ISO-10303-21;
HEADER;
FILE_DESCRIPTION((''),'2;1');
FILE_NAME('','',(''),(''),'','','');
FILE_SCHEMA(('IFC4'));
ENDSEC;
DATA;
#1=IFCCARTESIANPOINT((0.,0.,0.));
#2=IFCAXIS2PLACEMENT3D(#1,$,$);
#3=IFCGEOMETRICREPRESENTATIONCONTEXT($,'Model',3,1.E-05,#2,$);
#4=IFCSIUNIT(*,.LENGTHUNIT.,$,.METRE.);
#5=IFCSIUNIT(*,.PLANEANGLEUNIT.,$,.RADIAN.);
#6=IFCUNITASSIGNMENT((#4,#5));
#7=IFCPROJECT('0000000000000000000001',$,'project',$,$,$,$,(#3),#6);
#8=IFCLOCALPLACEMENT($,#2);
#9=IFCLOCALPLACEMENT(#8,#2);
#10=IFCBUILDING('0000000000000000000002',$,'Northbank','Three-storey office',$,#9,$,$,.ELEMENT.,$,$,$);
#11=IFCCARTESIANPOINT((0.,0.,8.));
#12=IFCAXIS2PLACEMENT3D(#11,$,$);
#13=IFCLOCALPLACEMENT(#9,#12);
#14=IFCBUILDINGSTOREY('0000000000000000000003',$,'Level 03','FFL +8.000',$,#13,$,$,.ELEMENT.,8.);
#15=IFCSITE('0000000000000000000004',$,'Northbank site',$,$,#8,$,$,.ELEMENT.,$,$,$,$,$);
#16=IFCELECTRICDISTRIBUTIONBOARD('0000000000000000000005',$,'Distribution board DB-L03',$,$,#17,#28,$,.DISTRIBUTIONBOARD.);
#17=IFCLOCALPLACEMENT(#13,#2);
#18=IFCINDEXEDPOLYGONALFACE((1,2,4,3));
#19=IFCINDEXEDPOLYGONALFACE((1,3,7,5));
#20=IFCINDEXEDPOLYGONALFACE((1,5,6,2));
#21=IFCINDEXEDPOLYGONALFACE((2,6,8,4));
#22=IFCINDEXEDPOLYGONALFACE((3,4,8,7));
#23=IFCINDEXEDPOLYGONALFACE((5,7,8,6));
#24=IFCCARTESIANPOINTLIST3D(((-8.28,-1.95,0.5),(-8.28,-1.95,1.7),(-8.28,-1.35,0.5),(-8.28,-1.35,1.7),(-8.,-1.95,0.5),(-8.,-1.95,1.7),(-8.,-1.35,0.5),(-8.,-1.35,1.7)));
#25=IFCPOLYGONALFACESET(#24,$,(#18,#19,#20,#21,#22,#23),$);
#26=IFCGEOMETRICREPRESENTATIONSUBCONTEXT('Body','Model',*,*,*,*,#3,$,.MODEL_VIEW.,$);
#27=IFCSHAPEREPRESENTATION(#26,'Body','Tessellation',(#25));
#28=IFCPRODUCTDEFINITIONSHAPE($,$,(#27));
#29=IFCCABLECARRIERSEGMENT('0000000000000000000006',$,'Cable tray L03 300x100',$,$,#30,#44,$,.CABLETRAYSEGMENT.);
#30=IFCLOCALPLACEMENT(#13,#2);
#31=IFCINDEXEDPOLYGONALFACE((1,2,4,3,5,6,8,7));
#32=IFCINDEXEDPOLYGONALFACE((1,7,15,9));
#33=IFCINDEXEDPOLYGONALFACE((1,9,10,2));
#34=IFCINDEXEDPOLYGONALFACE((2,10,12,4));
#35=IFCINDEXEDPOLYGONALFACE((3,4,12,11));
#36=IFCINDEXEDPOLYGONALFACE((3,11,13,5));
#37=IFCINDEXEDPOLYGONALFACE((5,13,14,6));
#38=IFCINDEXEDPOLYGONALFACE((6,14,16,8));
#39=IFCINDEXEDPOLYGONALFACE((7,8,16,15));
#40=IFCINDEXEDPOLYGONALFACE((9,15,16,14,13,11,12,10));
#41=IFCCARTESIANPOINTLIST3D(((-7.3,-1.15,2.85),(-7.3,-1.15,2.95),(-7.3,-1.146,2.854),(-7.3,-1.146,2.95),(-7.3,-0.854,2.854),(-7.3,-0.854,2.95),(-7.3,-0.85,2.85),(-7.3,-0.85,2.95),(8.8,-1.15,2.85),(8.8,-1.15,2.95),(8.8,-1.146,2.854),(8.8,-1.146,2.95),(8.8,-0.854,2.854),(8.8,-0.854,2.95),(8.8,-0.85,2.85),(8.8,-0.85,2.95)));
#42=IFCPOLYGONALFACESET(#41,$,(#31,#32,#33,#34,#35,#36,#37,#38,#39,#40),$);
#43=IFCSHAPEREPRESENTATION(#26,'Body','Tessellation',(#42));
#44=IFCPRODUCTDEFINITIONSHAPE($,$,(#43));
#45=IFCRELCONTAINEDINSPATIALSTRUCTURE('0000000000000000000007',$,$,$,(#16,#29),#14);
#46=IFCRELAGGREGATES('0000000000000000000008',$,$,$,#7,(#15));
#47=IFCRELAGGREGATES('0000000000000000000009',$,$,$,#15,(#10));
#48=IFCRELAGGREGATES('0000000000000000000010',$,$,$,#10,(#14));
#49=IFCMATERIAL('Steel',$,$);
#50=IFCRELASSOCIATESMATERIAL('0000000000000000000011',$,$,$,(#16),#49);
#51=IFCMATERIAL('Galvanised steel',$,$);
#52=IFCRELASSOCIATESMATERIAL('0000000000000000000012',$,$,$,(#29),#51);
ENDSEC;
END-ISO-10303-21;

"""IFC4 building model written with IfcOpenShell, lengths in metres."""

from ifc_helpers import new_model, si_unit, frame, origin, place, context, subcontext, project, spatial, rectangle, u_section, extrude, material, element, save


model = new_model("IFC4")

# Units and contexts
model_context = context("Model", 3, precision=1e-05, world=origin())
body_context = subcontext(model_context, "Body", "Model", "MODEL_VIEW")
ifc_project = project(units=[si_unit("LENGTHUNIT", "METRE"), si_unit("PLANEANGLEUNIT", "RADIAN")], contexts=[model_context])

# Site, building, storey
site_placement = place(None, origin())
site = spatial("IfcSite", under=ifc_project, at=site_placement, Name="Northbank site", CompositionType="ELEMENT")
building_placement = place(site_placement, origin())
building = spatial("IfcBuilding", under=site, at=building_placement, Name="Northbank", Description="Three-storey office", CompositionType="ELEMENT")
storey_placement = place(building_placement, frame((0.0, 0.0, 8.0)))
storey = spatial("IfcBuildingStorey", under=building, at=storey_placement, Name="Level 03", Description="FFL +8.000", CompositionType="ELEMENT", Elevation=8.0)

# Electric distribution board
ifc_material_1 = material(Name="Steel")
electric_distribution_board_placement = place(storey_placement, frame((0.0, 0.0, -8.0)))
element("IfcElectricDistributionBoard", 1, at=electric_distribution_board_placement, inside=storey, material=ifc_material_1, Name="Distribution board DB-L03", PredefinedType="DISTRIBUTIONBOARD", context=body_context, shape_type="SweptSolid", body=[
    extrude(rectangle(XDim=0.28, YDim=0.6), frame((-8.14, -1.65, 8.5)), (0.0, 0.0, 1.0), 1.2),
])

# Cable carrier segment
ifc_material_2 = material(Name="Galvanised steel")
cable_carrier_segment_1_placement = place(storey_placement, frame((0.0, 0.0, -8.0)))
element("IfcCableCarrierSegment", 2, at=cable_carrier_segment_1_placement, inside=storey, material=ifc_material_2, Name="Cable tray L03 300x100", PredefinedType="CABLETRAYSEGMENT", context=body_context, shape_type="SweptSolid", body=[
    extrude(u_section(Depth=0.3, FlangeWidth=0.1, WebThickness=0.004, FlangeThickness=0.004), frame((-7.3, -1.0, 10.9), z_axis=(1.0, 0.0, 0.0), x_axis=(0.0, 0.0, 1.0)), (0.0, 0.0, 1.0), 16.1),
])

save(model, "model.ifc")
